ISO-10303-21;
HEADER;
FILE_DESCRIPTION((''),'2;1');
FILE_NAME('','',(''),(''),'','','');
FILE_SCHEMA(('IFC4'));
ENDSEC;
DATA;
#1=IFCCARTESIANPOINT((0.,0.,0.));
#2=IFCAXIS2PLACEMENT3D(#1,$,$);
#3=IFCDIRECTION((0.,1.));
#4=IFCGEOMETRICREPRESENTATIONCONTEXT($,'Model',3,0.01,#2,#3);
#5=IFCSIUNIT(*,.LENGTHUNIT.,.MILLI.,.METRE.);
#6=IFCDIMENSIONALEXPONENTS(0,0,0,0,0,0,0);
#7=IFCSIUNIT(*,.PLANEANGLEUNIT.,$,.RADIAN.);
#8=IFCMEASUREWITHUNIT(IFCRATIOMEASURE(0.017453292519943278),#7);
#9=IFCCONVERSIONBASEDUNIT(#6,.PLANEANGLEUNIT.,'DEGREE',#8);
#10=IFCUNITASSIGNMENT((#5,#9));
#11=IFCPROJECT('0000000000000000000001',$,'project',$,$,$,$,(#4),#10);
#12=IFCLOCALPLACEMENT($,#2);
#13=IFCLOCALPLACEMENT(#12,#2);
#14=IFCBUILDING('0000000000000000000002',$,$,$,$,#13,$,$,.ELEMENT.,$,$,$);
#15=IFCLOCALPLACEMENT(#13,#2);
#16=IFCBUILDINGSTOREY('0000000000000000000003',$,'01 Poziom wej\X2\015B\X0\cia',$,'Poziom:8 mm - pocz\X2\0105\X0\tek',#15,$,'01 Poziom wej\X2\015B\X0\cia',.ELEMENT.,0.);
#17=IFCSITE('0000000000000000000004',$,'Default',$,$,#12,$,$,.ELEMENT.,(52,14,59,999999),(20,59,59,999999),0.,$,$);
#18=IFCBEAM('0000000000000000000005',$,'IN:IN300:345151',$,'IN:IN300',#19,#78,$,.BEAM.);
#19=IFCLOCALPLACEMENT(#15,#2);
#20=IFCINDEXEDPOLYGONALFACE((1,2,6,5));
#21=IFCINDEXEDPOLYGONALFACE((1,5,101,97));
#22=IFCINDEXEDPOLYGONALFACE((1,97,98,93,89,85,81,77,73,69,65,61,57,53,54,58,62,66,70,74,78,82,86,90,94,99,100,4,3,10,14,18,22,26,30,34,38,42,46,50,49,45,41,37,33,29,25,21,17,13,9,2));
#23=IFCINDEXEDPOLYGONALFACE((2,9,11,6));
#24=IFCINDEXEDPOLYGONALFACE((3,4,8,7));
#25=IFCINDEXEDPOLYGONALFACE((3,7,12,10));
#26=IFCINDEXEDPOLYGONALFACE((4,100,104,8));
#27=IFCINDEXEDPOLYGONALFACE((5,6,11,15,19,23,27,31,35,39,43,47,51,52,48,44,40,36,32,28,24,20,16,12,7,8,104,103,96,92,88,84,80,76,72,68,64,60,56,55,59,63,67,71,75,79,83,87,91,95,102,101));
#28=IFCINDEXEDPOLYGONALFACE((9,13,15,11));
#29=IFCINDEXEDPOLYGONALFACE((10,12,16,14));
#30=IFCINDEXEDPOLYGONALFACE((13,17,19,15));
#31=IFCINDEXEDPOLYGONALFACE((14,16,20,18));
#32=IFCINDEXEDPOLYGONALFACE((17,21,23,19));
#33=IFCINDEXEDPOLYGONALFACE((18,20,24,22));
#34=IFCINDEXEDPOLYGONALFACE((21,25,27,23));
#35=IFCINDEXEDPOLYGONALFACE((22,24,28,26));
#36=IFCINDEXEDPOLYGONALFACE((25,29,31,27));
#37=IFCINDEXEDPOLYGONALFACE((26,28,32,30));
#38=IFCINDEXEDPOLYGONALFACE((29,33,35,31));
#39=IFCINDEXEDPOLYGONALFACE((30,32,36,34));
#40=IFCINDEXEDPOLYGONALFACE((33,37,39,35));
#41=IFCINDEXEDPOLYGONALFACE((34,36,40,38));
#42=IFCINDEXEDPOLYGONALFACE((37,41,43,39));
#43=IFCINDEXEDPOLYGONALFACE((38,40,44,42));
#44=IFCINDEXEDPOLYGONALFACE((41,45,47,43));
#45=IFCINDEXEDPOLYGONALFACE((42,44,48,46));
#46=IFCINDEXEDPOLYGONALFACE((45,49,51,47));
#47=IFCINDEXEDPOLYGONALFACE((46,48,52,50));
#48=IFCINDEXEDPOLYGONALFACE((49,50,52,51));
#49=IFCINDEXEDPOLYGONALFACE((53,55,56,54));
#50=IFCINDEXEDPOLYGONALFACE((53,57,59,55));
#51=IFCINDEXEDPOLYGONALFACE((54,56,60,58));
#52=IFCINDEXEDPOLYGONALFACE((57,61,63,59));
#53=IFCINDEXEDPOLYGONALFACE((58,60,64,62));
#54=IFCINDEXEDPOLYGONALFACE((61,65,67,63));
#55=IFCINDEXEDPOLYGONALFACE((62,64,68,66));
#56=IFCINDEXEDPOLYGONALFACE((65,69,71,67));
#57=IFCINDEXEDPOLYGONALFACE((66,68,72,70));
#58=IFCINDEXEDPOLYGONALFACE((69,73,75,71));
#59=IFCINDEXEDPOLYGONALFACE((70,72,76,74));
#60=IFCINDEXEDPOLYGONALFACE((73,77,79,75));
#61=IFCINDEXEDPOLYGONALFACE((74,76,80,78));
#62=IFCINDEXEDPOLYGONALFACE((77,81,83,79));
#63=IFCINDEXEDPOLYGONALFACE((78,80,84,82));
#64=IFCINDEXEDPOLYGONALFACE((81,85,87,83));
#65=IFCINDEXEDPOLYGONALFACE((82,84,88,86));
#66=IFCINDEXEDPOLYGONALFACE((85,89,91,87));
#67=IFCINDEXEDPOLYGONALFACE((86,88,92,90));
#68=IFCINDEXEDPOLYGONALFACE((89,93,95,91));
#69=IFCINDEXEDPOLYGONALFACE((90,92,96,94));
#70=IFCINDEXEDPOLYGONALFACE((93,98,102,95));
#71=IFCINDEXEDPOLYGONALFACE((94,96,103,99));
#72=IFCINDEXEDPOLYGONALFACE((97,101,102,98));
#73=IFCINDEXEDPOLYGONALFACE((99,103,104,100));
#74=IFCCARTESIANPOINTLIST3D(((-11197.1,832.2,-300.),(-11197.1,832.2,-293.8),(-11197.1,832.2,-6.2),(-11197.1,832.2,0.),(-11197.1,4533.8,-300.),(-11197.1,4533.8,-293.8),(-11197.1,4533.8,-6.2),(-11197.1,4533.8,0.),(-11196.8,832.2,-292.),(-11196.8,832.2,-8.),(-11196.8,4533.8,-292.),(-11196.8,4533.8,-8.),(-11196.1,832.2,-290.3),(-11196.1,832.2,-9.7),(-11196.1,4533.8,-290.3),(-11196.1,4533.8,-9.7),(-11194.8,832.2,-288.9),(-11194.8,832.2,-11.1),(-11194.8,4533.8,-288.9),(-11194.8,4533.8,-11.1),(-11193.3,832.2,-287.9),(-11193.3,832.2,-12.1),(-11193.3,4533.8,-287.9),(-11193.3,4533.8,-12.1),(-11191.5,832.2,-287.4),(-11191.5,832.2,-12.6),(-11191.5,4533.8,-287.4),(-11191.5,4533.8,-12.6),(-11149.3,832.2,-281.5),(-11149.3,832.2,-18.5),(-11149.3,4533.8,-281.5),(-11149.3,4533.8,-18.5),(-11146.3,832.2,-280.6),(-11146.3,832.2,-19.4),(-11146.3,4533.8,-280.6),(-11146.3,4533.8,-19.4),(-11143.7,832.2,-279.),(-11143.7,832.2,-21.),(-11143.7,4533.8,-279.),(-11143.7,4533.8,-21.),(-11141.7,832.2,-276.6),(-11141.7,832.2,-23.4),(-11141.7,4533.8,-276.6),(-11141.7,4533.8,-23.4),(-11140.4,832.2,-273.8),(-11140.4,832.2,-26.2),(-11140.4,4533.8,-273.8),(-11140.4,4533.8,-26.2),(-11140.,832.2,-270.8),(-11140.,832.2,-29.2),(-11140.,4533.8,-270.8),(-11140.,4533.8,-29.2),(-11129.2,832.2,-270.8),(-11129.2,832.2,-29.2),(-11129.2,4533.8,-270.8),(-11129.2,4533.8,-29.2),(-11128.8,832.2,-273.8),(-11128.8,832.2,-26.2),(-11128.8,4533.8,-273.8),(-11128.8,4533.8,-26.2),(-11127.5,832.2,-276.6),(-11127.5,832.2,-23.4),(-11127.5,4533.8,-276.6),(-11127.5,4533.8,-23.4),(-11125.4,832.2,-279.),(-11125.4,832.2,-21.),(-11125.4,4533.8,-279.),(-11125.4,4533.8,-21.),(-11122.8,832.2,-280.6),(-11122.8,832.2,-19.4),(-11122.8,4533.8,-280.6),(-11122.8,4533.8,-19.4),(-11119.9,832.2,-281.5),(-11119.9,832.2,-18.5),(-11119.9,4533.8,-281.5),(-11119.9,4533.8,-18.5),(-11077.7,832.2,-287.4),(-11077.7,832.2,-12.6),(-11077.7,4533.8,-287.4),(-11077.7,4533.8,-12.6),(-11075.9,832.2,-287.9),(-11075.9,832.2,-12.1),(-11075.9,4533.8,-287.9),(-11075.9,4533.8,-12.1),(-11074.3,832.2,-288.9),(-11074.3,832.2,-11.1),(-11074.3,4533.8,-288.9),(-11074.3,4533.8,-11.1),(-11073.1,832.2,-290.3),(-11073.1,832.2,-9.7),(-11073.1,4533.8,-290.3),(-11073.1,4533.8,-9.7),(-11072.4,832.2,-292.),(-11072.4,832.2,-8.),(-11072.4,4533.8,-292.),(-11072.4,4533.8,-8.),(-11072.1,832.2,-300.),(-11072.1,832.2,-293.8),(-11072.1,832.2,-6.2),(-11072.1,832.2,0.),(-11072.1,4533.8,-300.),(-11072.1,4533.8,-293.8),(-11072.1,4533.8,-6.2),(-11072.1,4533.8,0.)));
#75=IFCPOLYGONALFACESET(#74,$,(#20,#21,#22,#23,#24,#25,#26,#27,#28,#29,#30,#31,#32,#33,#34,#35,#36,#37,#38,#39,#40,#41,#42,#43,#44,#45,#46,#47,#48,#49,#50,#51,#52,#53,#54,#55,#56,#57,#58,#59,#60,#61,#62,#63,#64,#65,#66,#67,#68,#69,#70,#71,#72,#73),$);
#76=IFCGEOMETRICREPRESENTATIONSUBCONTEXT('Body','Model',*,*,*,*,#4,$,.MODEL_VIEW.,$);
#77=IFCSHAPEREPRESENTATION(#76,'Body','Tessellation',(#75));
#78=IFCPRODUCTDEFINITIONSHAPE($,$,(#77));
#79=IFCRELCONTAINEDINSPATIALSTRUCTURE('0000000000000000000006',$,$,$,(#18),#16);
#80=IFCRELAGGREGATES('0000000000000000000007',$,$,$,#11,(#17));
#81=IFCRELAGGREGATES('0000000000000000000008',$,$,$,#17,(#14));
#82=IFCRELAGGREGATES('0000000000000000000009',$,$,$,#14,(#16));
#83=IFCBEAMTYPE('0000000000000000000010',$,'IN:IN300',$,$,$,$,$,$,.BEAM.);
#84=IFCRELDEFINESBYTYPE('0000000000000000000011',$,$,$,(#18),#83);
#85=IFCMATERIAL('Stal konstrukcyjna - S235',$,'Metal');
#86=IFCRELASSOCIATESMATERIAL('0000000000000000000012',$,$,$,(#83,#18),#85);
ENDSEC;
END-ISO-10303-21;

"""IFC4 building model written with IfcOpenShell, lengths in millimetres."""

from ifc_helpers import new_model, entity, si_unit, converted_unit, direction, frame, origin, place, context, subcontext, project, spatial, line, arc, indexed_curve, outline, extrude, source, transform, mapped, material, type_object, type_shapes, element, save


model = new_model("IFC4")

# Units and contexts
model_context = context("Model", 3, precision=0.01, world=origin(), true_north=direction((0.0, 1.0)))
body_context = subcontext(model_context, "Body", "Model", "MODEL_VIEW")
ifc_project = project(units=[si_unit("LENGTHUNIT", "METRE", prefix="MILLI"), converted_unit("PLANEANGLEUNIT", "DEGREE", entity("IfcRatioMeasure", 0.017453292519943278), si_unit("PLANEANGLEUNIT", "RADIAN"), dimensions=[0, 0, 0, 0, 0, 0, 0])], contexts=[model_context])

# Site, building, storey
site_placement = place(None, origin())
site = spatial("IfcSite", under=ifc_project, at=site_placement, Name="Default", CompositionType="ELEMENT", RefLatitude=(52, 14, 59, 999999), RefLongitude=(20, 59, 59, 999999), RefElevation=0.0)
building_placement = place(site_placement, origin())
building = spatial("IfcBuilding", under=site, at=building_placement, CompositionType="ELEMENT")
storey_placement = place(building_placement, origin())
storey = spatial("IfcBuildingStorey", under=building, at=storey_placement, Name="01 Poziom wejścia", ObjectType="Poziom:8 mm - początek", LongName="01 Poziom wejścia", CompositionType="ELEMENT", Elevation=0.0)

# Beam
ifc_material = material(Name="Stal konstrukcyjna - S235", Category="Metal")
beam_type_1 = type_object("IfcBeamType", Name="IN:IN300", PredefinedType="BEAM", material=ifc_material)
shared_shape_1 = source(origin(), body_context, "Body", "SweptSolid", [
    extrude(outline(indexed_curve([(143.8, -62.5), (150.0, -62.5), (150.0, 62.5), (143.8, 62.5), (139.6, 60.9), (137.4, 56.9), (131.5, 14.7), (127.9, 8.1), (120.8, 5.4), (-120.8, 5.4), (-127.9, 8.1), (-131.5, 14.7), (-137.4, 56.9), (-139.6, 60.9), (-143.8, 62.5), (-150.0, 62.5), (-150.0, -62.5), (-143.8, -62.5), (-139.6, -60.9), (-137.4, -56.9), (-131.5, -14.7), (-127.9, -8.1), (-120.8, -5.4), (120.8, -5.4), (127.9, -8.1), (131.5, -14.7), (137.4, -56.9), (139.6, -60.9)], segments=[line(1, 2, 3, 4), arc(4, 5, 6), line(6, 7), arc(7, 8, 9), line(9, 10), arc(10, 11, 12), line(12, 13), arc(13, 14, 15), line(15, 16, 17, 18), arc(18, 19, 20), line(20, 21), arc(21, 22, 23), line(23, 24), arc(24, 25, 26), line(26, 27), arc(27, 28, 1)], self_intersect=False)), frame((-1850.8, 0.0, 0.0), z_axis=(1.0, 0.0, 0.0), x_axis=(0.0, 0.0, -1.0)), (0.0, 0.0, 1.0), 3701.6),
])
type_shapes(beam_type_1, [shared_shape_1])
for number, where, z_axis, x_axis, name in (
    (1, (-11134.6, 2683.0, -150.0), (0.0, 0.0, 1.0), (0.0, -1.0, 0.0), "IN:IN300:345151"),
):
    element("IfcBeam", number, at=place(storey_placement, frame(where, z_axis=z_axis, x_axis=x_axis)), inside=storey, type_object=beam_type_1, material=ifc_material, Name=name, ObjectType="IN:IN300", PredefinedType="BEAM", context=body_context, shape_type="MappedRepresentation", body=[
        mapped(shared_shape_1, transform((0.0, 0.0, 0.0), scale=1.0)),
    ])

save(model, "model.ifc")
